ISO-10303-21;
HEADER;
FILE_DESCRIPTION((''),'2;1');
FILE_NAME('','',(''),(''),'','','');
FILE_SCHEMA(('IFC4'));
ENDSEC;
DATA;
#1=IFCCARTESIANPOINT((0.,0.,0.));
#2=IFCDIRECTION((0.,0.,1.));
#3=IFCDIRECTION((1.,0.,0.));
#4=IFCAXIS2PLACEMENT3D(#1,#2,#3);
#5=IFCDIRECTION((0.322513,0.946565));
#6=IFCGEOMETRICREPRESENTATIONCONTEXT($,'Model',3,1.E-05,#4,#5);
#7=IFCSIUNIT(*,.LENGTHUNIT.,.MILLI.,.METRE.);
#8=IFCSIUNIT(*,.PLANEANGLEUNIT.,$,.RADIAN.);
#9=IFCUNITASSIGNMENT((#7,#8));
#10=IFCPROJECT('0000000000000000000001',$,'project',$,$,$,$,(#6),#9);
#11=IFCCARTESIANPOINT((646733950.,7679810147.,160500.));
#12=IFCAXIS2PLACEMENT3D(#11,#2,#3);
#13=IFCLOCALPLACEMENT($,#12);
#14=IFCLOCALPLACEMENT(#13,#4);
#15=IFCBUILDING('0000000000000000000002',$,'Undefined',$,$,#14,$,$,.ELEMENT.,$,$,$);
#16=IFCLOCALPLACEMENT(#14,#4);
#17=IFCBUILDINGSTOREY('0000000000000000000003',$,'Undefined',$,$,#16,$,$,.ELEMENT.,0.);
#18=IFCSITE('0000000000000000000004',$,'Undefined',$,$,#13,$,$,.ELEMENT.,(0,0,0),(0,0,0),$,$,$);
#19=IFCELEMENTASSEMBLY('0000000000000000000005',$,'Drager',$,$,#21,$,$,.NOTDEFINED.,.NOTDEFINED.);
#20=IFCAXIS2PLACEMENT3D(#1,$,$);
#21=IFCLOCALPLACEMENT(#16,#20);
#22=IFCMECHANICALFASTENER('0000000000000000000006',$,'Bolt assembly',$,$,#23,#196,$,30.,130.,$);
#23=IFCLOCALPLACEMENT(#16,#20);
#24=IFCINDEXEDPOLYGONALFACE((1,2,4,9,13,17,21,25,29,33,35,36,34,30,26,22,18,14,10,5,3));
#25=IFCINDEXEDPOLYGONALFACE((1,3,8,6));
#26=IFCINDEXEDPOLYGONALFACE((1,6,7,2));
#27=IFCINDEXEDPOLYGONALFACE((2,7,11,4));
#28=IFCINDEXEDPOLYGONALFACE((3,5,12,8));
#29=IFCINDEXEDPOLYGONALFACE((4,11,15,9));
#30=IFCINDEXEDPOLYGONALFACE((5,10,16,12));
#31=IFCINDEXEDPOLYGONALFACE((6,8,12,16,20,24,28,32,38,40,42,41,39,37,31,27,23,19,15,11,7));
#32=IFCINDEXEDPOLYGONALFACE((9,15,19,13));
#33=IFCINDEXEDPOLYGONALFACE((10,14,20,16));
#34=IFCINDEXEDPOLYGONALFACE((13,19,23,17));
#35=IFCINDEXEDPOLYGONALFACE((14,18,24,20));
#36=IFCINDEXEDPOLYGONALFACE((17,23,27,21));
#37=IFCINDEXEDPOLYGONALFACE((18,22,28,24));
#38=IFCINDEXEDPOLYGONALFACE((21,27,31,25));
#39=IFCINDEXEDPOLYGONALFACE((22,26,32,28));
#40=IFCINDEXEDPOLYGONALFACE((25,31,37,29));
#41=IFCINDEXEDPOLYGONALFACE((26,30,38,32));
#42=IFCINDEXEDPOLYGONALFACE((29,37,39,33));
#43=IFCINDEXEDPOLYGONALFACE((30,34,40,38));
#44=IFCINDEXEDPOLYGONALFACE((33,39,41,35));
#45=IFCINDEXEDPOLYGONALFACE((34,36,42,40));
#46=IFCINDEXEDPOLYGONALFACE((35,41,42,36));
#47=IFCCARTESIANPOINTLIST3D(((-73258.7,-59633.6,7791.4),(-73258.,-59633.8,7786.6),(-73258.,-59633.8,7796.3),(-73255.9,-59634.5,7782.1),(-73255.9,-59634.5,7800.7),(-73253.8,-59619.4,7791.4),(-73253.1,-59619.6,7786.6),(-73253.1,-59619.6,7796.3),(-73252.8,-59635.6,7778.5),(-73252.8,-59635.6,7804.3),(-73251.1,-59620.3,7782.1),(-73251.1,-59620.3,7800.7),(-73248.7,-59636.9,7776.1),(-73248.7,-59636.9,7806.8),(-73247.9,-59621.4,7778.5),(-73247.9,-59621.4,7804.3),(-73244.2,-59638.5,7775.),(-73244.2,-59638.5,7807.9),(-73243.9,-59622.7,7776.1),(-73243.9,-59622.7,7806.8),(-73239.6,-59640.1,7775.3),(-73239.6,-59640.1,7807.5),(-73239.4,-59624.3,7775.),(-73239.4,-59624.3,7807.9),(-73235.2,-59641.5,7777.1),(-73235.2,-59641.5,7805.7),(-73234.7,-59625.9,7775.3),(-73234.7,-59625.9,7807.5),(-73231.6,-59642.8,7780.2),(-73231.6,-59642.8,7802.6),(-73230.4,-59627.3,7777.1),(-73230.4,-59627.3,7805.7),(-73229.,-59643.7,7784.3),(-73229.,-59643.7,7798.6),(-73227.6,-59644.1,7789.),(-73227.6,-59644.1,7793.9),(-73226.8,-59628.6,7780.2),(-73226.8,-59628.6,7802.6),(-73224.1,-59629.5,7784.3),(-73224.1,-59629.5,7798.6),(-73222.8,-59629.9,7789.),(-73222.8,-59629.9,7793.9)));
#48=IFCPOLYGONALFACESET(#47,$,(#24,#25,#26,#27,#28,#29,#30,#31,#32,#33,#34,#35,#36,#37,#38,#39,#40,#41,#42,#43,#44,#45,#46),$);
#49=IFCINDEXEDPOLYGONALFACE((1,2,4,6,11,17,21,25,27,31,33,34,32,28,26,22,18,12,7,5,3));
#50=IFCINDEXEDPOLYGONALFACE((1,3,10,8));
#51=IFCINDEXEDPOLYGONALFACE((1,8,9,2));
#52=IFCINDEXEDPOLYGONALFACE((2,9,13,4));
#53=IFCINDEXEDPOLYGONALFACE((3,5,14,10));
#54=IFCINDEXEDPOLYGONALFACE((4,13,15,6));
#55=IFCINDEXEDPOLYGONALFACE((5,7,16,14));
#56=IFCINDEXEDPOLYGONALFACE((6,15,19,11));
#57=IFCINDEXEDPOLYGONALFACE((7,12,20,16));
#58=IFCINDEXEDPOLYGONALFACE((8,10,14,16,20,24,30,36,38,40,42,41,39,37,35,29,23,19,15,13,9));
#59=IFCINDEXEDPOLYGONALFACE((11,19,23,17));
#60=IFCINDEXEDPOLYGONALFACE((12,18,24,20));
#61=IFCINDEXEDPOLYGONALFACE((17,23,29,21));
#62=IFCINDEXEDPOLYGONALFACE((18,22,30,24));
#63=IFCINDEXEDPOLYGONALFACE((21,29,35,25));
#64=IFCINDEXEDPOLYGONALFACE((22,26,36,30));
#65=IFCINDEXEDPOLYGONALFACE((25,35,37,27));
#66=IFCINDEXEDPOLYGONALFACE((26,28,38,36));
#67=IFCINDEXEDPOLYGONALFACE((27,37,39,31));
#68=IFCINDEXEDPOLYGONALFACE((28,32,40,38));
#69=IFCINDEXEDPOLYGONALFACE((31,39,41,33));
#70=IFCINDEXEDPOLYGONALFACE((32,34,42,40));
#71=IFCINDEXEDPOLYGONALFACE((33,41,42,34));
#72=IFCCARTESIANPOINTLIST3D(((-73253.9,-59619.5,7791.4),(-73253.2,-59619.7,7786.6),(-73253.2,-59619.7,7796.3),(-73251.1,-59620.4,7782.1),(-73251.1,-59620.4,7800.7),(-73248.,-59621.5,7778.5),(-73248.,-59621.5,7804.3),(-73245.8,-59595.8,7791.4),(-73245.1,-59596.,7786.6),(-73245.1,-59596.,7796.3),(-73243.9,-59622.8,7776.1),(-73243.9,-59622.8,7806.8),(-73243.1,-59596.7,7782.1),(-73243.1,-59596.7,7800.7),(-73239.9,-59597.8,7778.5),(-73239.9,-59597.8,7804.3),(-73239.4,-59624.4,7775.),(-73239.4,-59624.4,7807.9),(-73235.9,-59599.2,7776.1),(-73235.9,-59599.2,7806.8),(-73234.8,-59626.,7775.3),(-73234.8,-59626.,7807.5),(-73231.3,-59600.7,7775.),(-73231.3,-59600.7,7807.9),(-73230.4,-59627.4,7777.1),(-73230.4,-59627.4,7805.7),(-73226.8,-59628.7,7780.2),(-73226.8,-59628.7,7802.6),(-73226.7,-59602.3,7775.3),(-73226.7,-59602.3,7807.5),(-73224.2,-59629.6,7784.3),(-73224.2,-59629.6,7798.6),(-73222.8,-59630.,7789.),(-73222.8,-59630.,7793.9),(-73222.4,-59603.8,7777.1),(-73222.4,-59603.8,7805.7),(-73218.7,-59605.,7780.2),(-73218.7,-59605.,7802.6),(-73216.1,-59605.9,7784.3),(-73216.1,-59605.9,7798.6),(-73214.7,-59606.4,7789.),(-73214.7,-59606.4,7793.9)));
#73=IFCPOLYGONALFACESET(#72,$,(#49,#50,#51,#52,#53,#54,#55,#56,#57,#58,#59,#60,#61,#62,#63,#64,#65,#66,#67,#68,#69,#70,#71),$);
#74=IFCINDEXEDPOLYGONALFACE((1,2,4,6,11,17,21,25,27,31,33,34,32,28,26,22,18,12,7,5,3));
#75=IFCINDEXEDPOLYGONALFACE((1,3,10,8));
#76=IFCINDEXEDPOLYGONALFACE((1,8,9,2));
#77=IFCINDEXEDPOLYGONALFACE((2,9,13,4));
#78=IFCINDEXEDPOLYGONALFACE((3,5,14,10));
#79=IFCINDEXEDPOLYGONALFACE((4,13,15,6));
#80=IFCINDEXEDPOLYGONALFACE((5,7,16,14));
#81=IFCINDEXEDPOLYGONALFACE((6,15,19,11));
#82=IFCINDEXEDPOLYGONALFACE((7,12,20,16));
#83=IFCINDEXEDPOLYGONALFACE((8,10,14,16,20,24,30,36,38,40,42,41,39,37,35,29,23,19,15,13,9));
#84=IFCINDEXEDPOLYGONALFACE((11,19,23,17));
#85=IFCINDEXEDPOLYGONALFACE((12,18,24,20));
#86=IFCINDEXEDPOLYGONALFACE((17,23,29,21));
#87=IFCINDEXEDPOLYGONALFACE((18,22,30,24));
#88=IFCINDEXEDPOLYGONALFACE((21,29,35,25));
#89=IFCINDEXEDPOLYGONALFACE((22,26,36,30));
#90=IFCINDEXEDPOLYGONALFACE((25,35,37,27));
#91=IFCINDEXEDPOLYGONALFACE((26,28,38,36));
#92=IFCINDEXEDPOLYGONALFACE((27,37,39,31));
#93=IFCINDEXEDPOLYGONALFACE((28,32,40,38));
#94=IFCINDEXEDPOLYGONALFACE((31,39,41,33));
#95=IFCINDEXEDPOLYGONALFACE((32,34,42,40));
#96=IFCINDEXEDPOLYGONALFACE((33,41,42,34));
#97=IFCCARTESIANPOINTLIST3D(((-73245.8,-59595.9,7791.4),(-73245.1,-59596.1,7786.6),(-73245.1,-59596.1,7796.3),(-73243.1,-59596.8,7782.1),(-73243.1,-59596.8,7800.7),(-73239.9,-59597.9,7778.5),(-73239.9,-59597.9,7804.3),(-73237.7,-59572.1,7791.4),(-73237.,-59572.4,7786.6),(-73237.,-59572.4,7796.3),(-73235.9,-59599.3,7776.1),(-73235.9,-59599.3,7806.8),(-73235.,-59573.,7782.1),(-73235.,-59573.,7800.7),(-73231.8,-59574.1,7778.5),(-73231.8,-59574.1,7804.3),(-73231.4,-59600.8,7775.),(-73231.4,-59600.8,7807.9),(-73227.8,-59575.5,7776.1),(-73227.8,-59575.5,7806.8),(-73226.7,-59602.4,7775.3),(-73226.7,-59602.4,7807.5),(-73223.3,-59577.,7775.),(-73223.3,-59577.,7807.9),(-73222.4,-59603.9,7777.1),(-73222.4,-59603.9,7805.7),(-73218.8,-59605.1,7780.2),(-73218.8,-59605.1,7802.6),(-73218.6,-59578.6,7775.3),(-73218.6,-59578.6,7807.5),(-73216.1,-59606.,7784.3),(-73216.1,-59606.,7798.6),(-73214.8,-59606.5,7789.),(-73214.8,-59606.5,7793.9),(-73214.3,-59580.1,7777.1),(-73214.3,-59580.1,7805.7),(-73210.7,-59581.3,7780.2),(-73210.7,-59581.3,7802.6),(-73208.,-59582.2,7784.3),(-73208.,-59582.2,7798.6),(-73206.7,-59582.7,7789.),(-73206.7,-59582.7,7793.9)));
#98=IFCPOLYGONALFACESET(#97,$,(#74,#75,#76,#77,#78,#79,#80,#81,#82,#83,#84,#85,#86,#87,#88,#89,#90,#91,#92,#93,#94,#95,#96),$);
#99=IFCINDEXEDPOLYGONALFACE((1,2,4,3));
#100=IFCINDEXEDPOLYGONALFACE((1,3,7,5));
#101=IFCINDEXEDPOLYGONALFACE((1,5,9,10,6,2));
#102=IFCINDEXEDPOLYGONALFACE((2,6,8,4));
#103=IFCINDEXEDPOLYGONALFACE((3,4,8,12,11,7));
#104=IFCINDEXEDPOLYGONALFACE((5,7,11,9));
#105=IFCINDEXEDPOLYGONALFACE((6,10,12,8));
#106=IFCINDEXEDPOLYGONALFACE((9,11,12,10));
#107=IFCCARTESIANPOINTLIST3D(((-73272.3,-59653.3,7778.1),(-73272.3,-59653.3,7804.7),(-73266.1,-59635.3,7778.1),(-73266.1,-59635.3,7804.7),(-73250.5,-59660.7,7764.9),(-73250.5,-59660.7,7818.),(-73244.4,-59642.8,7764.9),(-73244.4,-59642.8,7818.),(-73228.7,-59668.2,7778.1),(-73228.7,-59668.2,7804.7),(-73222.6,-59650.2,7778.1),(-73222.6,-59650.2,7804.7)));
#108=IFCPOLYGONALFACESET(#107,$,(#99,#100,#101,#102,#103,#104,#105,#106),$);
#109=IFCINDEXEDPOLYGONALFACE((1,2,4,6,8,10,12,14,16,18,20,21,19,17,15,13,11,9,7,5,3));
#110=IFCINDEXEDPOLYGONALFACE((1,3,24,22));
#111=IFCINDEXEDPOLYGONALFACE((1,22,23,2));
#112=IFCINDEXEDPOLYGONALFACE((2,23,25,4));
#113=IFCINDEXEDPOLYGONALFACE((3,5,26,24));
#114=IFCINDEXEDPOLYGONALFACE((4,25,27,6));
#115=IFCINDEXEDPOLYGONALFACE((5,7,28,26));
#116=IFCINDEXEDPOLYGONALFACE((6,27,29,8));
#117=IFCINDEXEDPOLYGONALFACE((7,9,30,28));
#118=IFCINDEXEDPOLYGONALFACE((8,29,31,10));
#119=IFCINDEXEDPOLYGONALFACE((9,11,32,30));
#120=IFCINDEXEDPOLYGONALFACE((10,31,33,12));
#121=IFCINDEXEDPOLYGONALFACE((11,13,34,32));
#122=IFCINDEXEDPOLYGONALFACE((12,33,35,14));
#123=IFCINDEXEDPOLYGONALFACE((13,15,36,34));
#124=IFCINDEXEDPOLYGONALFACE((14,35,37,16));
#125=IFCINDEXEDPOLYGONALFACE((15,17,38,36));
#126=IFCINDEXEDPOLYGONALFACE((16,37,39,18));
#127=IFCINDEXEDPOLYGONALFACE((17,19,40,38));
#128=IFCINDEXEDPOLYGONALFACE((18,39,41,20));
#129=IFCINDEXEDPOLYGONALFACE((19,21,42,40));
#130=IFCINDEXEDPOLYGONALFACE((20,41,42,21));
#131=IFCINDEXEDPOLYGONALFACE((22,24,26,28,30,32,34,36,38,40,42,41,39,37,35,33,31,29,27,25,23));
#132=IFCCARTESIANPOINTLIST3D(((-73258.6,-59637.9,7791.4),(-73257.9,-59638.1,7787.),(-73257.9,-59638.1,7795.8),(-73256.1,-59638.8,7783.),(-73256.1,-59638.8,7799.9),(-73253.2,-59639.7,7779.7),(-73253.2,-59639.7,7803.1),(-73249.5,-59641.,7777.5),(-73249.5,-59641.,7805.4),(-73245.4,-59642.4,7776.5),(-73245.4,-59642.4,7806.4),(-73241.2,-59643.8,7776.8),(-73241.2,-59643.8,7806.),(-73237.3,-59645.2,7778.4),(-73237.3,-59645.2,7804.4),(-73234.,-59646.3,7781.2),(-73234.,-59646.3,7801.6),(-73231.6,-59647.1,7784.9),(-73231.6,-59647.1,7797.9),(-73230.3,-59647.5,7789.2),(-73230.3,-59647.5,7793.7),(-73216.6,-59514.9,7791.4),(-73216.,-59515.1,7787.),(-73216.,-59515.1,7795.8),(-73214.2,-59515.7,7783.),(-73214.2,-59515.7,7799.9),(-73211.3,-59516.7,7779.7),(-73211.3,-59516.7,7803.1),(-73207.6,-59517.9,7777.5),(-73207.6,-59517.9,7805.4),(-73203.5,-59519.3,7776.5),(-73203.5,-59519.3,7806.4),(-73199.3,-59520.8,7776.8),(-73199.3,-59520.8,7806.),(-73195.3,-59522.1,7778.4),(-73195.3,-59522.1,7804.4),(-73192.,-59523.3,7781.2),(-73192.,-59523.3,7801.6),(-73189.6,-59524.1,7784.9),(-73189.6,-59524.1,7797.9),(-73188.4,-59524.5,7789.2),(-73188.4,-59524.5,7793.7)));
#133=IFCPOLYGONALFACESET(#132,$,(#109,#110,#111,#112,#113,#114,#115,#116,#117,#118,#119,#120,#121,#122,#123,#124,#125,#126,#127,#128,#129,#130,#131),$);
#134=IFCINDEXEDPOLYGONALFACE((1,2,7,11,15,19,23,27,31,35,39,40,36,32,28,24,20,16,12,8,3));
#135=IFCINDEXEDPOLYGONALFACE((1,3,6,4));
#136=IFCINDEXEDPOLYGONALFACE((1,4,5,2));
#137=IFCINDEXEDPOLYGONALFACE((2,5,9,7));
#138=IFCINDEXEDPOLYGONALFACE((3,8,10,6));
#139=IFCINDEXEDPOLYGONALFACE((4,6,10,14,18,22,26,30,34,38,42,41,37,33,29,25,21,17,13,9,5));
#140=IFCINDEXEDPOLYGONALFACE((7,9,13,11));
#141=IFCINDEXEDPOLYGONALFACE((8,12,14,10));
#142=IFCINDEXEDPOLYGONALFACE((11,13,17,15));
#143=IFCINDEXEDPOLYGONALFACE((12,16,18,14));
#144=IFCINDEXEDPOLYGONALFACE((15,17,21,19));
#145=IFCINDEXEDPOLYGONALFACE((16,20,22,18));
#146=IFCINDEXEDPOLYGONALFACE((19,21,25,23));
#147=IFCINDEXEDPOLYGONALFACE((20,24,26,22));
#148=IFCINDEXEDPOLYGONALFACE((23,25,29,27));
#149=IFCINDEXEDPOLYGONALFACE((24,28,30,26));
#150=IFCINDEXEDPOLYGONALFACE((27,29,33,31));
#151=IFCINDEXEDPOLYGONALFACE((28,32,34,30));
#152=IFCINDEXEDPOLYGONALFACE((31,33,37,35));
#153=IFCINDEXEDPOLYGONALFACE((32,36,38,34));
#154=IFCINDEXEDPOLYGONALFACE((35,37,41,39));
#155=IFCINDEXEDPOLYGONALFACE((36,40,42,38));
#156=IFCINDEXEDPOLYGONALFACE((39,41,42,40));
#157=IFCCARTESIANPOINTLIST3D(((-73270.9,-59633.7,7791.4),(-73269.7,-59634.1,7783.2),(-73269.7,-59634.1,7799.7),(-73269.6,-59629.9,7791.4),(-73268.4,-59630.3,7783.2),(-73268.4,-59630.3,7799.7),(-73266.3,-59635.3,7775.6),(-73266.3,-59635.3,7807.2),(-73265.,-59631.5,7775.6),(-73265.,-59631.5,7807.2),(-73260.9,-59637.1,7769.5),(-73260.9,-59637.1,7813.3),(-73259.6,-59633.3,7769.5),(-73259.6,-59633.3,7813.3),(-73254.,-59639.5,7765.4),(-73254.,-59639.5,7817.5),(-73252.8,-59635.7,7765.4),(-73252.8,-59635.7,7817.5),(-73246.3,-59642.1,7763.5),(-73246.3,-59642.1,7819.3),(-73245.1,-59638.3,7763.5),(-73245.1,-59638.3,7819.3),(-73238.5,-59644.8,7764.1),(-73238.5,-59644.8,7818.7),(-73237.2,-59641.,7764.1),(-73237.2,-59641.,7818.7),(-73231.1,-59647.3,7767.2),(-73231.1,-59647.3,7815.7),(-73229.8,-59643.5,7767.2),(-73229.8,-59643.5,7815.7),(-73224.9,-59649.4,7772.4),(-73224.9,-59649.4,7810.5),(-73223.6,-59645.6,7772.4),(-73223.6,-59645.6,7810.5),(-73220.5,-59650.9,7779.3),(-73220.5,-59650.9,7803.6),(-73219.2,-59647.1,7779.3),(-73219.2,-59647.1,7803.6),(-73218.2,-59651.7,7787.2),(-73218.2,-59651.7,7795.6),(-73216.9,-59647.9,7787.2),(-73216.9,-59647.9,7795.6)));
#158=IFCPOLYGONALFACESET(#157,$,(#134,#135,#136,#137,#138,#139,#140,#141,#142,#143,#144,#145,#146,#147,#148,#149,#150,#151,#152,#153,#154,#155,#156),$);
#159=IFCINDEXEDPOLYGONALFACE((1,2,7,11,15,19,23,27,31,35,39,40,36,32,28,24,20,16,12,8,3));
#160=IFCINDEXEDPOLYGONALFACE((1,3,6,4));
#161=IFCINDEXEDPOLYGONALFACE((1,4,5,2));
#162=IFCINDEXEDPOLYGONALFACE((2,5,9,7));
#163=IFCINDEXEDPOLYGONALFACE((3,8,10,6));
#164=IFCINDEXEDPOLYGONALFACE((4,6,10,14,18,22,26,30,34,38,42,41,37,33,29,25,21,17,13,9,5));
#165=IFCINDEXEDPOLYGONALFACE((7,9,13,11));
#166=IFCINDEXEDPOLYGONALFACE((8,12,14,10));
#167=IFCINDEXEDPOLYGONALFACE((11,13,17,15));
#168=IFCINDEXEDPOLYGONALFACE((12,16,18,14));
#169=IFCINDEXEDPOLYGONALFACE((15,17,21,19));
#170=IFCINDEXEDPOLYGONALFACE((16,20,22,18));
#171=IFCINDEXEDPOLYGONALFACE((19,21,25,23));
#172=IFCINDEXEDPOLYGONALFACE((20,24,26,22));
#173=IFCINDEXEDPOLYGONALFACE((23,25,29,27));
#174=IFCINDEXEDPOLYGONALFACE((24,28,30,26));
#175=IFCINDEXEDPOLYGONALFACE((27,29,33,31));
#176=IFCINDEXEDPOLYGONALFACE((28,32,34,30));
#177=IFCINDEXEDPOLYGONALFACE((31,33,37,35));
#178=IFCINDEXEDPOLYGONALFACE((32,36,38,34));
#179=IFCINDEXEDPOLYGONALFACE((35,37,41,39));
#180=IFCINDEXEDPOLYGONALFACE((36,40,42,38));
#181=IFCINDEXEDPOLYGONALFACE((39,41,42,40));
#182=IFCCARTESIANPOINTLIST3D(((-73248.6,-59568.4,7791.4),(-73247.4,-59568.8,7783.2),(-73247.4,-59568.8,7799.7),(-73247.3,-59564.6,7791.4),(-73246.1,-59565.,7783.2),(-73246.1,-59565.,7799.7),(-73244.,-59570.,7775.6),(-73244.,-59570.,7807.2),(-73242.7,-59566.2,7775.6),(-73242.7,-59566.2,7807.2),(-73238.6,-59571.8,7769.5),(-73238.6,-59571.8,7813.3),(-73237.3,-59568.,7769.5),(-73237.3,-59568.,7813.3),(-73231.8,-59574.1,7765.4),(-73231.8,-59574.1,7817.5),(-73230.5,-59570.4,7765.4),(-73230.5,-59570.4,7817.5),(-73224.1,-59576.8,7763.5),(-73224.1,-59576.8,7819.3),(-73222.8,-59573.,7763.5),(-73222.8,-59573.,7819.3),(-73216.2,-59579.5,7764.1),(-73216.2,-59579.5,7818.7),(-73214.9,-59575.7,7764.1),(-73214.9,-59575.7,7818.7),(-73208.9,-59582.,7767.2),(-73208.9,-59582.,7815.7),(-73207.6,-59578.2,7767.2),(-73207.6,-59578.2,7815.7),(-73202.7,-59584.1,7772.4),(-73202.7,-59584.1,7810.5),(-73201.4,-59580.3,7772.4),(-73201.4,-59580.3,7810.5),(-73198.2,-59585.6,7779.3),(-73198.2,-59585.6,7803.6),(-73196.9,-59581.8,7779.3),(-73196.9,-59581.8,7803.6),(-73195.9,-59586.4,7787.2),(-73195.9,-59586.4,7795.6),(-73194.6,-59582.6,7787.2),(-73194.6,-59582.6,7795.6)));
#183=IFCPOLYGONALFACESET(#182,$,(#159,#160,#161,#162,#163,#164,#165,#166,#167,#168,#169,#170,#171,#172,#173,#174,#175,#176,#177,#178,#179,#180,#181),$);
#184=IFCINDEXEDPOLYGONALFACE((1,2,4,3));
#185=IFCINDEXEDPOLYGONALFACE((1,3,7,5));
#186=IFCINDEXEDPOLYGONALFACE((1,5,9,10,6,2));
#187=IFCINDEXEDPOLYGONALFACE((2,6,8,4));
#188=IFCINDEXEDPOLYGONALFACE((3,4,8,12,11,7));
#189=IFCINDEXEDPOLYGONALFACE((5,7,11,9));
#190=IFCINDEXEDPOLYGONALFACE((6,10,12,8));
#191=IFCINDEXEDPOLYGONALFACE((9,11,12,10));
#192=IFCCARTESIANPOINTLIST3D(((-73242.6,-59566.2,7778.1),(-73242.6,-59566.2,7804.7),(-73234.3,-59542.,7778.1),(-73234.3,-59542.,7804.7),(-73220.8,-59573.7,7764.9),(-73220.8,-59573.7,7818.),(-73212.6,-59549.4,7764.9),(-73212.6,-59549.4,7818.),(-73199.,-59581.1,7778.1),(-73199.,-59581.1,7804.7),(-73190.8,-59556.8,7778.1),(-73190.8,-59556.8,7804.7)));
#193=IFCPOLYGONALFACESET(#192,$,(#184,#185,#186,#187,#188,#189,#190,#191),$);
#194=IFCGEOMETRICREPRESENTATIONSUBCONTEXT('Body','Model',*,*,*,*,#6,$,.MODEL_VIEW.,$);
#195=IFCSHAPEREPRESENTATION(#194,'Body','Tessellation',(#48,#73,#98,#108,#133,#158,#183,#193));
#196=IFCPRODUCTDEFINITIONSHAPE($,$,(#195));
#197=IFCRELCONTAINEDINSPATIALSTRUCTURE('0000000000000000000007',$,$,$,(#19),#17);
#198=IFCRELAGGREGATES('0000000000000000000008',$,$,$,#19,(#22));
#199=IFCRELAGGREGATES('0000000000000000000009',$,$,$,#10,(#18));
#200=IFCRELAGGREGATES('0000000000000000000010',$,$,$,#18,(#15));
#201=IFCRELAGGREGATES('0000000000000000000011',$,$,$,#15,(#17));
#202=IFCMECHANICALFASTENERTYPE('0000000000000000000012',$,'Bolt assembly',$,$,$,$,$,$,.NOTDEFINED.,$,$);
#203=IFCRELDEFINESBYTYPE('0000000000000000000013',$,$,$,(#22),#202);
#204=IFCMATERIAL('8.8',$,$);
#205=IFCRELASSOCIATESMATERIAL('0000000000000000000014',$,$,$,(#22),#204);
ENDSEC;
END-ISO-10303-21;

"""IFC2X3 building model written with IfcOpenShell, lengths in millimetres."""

from ifc_helpers import new_model, si_unit, direction, frame, origin_with_axes, origin_2d_with_axis, place, context, subcontext, project, spatial, polyline, circle, outline, extrude, source, transform, mapped, material, type_object, element, aggregate, save


model = new_model("IFC2X3")

# Units and contexts
model_context = context("Model", 3, precision=1e-05, world=origin_with_axes(), true_north=direction((0.322513, 0.946565)))
body_context = subcontext(model_context, "Body", "Model", "MODEL_VIEW")
ifc_project = project(units=[si_unit("LENGTHUNIT", "METRE", prefix="MILLI"), si_unit("PLANEANGLEUNIT", "RADIAN")], contexts=[model_context])

# Site, building, storey
site_placement = place(None, frame((646733950.0, 7679810147.0, 160500.0), z_axis=(0.0, 0.0, 1.0), x_axis=(1.0, 0.0, 0.0)))
site = spatial("IfcSite", under=ifc_project, at=site_placement, Name="Undefined", CompositionType="ELEMENT", RefLatitude=(0, 0, 0), RefLongitude=(0, 0, 0))
building_placement = place(site_placement, origin_with_axes())
building = spatial("IfcBuilding", under=site, at=building_placement, Name="Undefined", CompositionType="ELEMENT")
storey_placement = place(building_placement, origin_with_axes())
storey = spatial("IfcBuildingStorey", under=building, at=storey_placement, Name="Undefined", CompositionType="ELEMENT", Elevation=0.0)

# Element assembly
assembly_1_placement = place(storey_placement, origin_with_axes())
assembly_1 = element("IfcElementAssembly", 1, at=assembly_1_placement, inside=storey, Name="Drager", AssemblyPlace="NOTDEFINED", PredefinedType="NOTDEFINED")

# Mechanical fastener
ifc_material_1 = material(Name="8.8")
mechanical_fastener_type = type_object("IfcMechanicalFastenerType", Name="Bolt assembly")
shared_shape_1 = source(origin_with_axes(), body_context, "Body", "SweptSolid", [
    extrude(circle(Radius=16.5, at=origin_2d_with_axis()), frame((0.0, -7.4, 0.0), z_axis=(0.0, 1.0, 0.0), x_axis=(1.0, 0.0, 0.0)), (0.0, 0.0, 1.0), 15.0),
    extrude(circle(Radius=16.5, at=origin_2d_with_axis()), frame((0.0, 7.5, 0.0), z_axis=(0.0, 1.0, 0.0), x_axis=(1.0, 0.0, 0.0)), (0.0, 0.0, 1.0), 25.0),
    extrude(circle(Radius=16.5, at=origin_2d_with_axis()), frame((0.0, 32.4, 0.0), z_axis=(0.0, 1.0, 0.0), x_axis=(1.0, 0.0, 0.0)), (0.0, 0.0, 1.0), 25.1),
    extrude(outline(polyline([(23.0, -13.3), (23.0, 13.3), (0.0, 26.6), (-23.0, 13.3), (-23.0, -13.3), (0.0, -26.6), (23.0, -13.3)])), frame((0.0, -30.5, 0.0), z_axis=(0.0, 1.0, 0.0), x_axis=(1.0, 0.0, 0.0)), (0.0, 0.0, 1.0), 19.0),
    extrude(circle(Radius=15.0, at=origin_2d_with_axis()), frame((0.0, -11.5, 0.0), z_axis=(0.0, 1.0, 0.0), x_axis=(1.0, 0.0, 0.0)), (0.0, 0.0, 1.0), 130.0),
    extrude(circle(Radius=28.0, at=origin_2d_with_axis()), frame((0.0, -11.5, 0.0), z_axis=(0.0, 1.0, 0.0), x_axis=(1.0, 0.0, 0.0)), (0.0, 0.0, 1.0), 4.0),
    extrude(circle(Radius=28.0, at=origin_2d_with_axis()), frame((0.0, 57.5, 0.0), z_axis=(0.0, 1.0, 0.0), x_axis=(1.0, 0.0, 0.0)), (0.0, 0.0, 1.0), 4.0),
    extrude(outline(polyline([(23.0, -13.3), (23.0, 13.3), (0.0, 26.6), (-23.0, 13.3), (-23.0, -13.3), (0.0, -26.6), (23.0, -13.3)])), frame((0.0, 61.5, 0.0), z_axis=(0.0, 1.0, 0.0), x_axis=(1.0, 0.0, 0.0)), (0.0, 0.0, 1.0), 25.6),
])
mechanical_fastener_1_placement = place(assembly_1_placement, frame((-73240.7, -59631.9, 7791.4), z_axis=(0.0, 0.0, -1.0), x_axis=(-0.946565, 0.322513, 0.0)))
mechanical_fastener_1 = element("IfcMechanicalFastener", 2, at=mechanical_fastener_1_placement, type_object=mechanical_fastener_type, material=ifc_material_1, Name="Bolt assembly", NominalDiameter=30.0, NominalLength=130.0, context=body_context, shape_type="MappedRepresentation", body=[
    mapped(shared_shape_1, transform((0.0, 0.0, 0.0))),
])
aggregate(assembly_1, [mechanical_fastener_1])

save(model, "model.ifc")
